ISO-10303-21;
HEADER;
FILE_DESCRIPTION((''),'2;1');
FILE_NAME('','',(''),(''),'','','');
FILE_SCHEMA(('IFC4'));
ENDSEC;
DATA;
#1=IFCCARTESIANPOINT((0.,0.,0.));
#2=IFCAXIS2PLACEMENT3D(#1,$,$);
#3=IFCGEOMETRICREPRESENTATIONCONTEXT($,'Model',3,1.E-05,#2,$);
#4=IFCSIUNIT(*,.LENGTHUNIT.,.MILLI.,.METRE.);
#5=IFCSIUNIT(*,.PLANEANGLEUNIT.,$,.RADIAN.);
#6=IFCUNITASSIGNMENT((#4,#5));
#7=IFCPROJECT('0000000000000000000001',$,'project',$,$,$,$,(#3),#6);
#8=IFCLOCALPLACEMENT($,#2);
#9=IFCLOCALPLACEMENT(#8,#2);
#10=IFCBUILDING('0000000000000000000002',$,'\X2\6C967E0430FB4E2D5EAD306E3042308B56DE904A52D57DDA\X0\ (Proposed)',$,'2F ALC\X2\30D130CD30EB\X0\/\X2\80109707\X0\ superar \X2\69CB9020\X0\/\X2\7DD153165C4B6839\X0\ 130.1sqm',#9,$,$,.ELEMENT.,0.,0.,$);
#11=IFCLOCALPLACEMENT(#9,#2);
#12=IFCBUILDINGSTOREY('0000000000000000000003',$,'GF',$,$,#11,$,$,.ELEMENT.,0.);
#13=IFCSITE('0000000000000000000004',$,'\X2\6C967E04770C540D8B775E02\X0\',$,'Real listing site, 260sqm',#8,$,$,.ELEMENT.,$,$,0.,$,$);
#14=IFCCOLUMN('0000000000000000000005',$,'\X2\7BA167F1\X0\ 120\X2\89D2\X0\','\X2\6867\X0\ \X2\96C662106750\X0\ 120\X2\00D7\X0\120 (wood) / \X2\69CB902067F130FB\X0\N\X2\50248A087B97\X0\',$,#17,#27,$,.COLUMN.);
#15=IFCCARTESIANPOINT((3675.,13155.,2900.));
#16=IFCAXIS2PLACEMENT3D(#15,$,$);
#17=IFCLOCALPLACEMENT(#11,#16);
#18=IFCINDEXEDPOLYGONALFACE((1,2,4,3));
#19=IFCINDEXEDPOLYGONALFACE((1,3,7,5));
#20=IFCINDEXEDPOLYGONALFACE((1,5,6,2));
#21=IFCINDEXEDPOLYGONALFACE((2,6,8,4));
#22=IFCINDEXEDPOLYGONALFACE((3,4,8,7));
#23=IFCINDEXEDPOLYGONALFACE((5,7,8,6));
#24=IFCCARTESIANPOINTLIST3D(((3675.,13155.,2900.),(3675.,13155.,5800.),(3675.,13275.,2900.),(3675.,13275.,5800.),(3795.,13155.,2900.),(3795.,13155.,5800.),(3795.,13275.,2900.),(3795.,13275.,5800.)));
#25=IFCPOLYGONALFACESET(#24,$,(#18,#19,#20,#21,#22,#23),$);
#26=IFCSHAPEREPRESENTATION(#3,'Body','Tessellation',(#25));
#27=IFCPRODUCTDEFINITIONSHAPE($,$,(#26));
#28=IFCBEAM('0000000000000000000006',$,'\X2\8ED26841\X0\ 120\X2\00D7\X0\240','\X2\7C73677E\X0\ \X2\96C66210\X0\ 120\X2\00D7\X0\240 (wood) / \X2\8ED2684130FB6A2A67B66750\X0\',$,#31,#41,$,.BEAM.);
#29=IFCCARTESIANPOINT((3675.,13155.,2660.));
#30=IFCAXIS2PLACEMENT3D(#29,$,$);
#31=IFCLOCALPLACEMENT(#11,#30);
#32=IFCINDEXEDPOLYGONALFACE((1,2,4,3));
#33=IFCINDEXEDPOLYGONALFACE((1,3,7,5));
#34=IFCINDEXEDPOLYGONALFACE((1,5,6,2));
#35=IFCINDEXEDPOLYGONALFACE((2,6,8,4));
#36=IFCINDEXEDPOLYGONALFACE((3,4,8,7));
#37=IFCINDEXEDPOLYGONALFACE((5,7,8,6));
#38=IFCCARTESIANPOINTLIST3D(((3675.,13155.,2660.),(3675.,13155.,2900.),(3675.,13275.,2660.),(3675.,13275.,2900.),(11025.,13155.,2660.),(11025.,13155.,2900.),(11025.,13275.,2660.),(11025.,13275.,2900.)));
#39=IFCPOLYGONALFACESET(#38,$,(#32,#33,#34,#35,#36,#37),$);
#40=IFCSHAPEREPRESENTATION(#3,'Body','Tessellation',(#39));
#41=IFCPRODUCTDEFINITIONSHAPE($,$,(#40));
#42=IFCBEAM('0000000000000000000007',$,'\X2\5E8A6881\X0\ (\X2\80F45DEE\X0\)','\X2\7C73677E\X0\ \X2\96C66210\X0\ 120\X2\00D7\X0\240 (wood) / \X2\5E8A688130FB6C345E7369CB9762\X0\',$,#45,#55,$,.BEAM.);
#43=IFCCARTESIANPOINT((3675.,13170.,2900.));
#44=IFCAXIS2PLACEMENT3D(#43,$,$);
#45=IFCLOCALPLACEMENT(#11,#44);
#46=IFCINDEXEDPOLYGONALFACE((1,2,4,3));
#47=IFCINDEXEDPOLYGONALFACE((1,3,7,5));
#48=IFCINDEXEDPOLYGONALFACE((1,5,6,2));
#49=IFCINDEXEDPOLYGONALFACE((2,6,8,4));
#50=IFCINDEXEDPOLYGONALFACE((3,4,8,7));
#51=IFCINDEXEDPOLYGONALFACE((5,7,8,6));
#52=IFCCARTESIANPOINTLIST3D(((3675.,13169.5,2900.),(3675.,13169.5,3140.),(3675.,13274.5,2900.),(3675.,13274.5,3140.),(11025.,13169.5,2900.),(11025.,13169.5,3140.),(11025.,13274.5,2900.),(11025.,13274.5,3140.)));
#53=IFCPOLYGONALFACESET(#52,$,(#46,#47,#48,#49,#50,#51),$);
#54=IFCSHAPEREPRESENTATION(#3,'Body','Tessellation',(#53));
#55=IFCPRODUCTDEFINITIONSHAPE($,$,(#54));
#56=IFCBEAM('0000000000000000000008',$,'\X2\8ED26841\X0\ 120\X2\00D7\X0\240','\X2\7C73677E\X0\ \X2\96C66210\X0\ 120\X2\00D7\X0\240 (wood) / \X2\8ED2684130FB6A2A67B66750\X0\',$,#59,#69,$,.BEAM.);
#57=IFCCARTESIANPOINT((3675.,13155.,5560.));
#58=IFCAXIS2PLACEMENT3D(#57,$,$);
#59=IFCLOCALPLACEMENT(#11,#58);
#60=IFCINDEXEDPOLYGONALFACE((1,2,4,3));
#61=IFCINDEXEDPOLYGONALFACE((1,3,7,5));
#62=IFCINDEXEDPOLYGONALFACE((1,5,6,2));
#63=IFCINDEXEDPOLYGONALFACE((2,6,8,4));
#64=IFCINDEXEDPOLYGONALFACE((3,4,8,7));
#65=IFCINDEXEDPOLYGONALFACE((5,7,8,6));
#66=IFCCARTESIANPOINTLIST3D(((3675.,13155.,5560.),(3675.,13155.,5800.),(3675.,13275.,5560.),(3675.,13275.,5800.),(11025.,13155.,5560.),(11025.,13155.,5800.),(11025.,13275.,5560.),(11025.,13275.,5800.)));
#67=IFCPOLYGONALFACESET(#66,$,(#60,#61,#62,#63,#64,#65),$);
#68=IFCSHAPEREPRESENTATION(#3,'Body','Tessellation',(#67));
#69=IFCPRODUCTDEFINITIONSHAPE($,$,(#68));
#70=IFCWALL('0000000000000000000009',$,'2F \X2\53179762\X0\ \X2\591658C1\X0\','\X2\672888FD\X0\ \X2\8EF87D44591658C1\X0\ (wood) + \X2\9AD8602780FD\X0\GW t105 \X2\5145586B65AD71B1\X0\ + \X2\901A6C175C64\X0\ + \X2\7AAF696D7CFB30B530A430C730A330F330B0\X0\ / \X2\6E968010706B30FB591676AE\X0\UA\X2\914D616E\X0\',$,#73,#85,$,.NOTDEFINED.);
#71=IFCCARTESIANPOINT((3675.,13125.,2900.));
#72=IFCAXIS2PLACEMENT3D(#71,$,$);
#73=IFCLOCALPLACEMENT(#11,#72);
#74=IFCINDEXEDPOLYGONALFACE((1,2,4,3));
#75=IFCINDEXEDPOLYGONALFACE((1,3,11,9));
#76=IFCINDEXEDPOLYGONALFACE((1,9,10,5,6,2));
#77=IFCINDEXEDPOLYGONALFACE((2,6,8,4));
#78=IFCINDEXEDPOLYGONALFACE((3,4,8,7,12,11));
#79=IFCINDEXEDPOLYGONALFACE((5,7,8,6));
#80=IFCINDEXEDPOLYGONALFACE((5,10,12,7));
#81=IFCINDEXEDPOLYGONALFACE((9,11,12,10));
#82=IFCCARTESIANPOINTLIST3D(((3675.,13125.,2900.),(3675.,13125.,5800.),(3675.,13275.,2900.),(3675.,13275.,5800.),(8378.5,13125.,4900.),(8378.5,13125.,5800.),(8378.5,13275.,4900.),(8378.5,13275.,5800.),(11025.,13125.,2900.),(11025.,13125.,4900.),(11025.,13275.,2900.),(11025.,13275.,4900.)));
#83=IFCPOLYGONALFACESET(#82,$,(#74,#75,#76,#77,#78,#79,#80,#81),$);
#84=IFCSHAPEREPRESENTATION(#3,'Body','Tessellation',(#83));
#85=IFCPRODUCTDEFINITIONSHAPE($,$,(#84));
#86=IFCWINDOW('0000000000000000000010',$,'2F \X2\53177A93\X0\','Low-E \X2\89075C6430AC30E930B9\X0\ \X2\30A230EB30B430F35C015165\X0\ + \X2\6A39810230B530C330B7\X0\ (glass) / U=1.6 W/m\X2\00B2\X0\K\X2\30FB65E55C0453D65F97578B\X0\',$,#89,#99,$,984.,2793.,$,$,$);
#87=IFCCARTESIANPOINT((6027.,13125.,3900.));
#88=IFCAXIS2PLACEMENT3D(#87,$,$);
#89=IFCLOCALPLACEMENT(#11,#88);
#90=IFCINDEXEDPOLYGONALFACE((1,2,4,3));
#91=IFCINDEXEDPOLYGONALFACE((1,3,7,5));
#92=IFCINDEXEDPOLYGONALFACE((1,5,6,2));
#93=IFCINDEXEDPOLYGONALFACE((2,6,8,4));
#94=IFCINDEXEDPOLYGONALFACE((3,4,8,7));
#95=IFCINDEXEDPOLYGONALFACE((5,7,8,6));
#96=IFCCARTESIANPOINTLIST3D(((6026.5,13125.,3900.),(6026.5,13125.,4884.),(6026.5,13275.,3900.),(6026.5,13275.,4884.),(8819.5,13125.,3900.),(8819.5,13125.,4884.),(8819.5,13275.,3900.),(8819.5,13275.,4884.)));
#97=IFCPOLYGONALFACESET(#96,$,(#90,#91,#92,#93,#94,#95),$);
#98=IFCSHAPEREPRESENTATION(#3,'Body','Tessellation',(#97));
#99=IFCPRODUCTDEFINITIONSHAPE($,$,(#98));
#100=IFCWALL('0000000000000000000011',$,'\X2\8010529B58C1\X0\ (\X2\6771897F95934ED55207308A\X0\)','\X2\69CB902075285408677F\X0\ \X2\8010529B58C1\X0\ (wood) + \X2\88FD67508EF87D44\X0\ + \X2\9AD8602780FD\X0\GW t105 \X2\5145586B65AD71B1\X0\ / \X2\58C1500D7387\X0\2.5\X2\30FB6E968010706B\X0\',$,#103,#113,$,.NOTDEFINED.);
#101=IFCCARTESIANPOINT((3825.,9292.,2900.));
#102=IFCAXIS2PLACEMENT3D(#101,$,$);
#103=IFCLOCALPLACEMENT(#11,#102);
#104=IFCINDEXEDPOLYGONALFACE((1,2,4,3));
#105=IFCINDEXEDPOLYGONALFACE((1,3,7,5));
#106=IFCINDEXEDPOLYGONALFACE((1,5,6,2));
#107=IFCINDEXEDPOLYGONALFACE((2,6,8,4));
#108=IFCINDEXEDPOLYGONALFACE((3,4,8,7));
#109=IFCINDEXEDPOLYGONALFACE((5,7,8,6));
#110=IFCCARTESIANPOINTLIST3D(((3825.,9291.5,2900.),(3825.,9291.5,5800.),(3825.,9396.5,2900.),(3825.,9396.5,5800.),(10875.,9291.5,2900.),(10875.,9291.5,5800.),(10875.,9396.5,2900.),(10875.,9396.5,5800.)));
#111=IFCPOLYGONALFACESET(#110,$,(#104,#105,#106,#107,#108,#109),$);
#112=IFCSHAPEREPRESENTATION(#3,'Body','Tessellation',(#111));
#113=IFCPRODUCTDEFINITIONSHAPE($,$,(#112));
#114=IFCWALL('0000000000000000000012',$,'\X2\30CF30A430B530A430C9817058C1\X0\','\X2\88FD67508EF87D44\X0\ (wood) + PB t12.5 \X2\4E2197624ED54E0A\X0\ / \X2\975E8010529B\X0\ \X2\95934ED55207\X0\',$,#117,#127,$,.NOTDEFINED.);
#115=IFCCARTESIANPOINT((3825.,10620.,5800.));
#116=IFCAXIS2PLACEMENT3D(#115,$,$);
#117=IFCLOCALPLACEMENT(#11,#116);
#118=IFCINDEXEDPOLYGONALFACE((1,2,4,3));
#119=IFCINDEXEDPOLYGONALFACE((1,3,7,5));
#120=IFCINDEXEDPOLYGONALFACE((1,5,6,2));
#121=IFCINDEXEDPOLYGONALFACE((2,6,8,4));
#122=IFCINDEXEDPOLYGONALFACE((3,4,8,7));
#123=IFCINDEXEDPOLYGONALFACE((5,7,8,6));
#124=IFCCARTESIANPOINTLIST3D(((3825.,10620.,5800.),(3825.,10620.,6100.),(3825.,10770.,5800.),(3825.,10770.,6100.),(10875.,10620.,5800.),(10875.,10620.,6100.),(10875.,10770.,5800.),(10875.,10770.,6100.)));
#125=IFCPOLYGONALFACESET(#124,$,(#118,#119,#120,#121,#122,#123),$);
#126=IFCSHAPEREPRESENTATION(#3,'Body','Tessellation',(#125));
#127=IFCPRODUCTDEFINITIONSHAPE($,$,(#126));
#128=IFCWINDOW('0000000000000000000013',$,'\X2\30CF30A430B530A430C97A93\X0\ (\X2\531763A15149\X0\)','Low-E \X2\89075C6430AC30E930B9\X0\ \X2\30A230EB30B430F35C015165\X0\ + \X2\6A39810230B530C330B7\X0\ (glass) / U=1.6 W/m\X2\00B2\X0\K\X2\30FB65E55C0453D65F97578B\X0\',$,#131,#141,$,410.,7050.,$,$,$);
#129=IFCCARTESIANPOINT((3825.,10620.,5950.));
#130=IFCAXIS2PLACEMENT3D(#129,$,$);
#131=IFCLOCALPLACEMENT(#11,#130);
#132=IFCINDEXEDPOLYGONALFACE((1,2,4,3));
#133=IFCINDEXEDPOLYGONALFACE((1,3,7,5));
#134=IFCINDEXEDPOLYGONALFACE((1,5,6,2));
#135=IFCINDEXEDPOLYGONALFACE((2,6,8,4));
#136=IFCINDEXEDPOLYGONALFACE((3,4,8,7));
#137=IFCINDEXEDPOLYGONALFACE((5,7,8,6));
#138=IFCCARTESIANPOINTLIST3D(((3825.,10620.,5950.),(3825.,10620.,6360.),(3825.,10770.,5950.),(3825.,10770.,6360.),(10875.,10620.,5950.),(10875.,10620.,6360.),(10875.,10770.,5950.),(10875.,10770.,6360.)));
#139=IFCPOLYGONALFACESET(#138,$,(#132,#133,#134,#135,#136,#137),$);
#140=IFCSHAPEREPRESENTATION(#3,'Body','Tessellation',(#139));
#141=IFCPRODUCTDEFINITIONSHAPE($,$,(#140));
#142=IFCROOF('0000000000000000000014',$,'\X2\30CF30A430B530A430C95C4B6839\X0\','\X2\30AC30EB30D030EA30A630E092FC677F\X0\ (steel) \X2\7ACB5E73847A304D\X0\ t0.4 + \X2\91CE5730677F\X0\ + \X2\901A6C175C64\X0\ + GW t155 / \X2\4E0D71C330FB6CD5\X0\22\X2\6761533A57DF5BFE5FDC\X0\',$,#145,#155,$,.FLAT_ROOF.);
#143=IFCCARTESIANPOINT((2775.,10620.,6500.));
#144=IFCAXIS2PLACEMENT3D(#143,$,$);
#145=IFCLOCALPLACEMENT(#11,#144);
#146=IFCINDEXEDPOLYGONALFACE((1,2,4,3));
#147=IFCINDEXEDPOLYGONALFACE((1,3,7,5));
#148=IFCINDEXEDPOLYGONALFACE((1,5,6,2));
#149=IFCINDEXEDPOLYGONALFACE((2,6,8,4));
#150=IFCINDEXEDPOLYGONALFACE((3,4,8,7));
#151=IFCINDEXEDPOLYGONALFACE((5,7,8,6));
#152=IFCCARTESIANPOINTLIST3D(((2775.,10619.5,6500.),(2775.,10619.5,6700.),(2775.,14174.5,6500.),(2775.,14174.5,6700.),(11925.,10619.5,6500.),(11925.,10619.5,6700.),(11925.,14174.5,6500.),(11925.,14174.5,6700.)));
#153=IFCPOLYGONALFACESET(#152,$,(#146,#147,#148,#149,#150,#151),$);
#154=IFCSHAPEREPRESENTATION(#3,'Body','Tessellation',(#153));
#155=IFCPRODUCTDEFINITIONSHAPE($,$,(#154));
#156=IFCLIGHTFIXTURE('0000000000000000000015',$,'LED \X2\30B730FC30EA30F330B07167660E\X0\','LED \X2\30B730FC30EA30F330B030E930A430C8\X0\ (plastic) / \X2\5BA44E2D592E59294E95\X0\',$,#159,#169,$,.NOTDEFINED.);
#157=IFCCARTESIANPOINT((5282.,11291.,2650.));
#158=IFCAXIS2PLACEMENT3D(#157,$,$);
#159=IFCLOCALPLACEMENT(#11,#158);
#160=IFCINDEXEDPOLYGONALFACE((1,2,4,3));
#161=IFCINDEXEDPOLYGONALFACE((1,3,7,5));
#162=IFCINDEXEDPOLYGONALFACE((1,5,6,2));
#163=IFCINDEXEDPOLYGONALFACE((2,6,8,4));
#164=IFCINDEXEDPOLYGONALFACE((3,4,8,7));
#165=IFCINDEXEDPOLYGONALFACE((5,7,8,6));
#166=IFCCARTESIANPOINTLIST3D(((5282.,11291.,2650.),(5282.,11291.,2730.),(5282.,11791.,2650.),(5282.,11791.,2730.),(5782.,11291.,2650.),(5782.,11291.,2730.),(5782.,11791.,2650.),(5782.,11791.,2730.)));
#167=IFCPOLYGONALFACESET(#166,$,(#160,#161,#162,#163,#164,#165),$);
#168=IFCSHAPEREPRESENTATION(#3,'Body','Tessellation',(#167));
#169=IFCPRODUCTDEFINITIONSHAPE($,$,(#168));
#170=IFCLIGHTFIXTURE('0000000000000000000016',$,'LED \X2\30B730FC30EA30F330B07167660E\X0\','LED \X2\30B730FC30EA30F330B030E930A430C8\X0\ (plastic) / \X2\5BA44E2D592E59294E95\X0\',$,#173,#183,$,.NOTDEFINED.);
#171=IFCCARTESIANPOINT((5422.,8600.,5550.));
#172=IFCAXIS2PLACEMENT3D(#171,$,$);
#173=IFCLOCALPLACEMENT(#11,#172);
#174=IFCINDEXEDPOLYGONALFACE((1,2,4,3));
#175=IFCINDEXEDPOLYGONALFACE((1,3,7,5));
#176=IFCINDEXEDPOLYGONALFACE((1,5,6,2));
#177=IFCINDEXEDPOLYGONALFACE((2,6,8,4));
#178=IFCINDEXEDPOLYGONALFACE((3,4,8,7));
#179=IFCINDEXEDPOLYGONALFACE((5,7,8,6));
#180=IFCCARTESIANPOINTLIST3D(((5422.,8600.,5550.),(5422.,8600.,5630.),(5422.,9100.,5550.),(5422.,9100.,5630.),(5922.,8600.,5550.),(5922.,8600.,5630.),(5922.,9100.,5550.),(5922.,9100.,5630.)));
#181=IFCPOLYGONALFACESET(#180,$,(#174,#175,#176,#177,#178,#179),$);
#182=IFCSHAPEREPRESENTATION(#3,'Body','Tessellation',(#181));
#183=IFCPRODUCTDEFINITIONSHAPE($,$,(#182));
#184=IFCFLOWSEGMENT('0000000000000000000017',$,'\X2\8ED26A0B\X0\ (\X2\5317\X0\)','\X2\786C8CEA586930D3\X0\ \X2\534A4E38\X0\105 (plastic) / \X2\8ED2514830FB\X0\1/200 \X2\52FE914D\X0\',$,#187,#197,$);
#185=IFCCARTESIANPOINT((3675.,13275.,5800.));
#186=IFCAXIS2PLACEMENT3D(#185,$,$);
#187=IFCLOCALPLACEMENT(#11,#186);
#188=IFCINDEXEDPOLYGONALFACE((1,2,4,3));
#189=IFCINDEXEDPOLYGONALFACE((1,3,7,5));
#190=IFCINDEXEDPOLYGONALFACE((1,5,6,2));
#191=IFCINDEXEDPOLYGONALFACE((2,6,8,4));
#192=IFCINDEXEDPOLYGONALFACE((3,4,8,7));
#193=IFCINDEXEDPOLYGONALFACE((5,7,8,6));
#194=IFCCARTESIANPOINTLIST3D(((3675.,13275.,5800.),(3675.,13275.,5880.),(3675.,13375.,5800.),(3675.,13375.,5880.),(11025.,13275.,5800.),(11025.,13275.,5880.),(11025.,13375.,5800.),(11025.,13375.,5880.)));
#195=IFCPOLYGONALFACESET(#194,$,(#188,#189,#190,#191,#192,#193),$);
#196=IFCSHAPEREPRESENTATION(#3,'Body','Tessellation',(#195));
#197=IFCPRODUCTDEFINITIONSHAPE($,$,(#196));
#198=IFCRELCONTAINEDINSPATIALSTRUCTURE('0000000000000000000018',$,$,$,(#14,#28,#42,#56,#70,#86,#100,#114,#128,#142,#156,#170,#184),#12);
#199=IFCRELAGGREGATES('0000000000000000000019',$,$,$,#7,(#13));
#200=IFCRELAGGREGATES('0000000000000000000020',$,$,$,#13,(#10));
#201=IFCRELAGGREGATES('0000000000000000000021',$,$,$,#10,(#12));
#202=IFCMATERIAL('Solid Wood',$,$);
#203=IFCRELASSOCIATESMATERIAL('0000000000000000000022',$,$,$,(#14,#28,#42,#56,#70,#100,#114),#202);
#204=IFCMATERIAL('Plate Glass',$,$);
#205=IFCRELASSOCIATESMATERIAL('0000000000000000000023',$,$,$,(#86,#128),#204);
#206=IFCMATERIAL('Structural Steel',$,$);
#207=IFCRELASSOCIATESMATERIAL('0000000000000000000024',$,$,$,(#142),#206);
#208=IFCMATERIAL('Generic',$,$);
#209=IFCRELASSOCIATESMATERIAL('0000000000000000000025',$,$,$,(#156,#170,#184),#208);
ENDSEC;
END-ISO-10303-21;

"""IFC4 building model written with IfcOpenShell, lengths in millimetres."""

from ifc_helpers import new_model, si_unit, frame, frame_2d, origin, place, context, project, spatial, rectangle, extrude, material, element, fill, save


model = new_model("IFC4")

# Units and contexts
model_context = context("Model", 3, precision=1e-05, world=origin())
ifc_project = project(units=[si_unit("LENGTHUNIT", "METRE", prefix="MILLI"), si_unit("PLANEANGLEUNIT", "RADIAN")], contexts=[model_context])

# Site, building, storey
site_placement = place(None, origin())
site = spatial("IfcSite", under=ifc_project, at=site_placement, Name="沖縄県名護市", ObjectType="Real listing site, 260sqm", CompositionType="ELEMENT", RefElevation=0.0)
building_placement = place(site_placement, origin())
building = spatial("IfcBuilding", under=site, at=building_placement, Name="沖縄・中庭のある回遊動線 (Proposed)", ObjectType="2F ALCパネル/耐震 superar 構造/緑化屋根 130.1sqm", CompositionType="ELEMENT", ElevationOfRefHeight=0.0, ElevationOfTerrain=0.0)
storey_placement = place(building_placement, origin())
storey = spatial("IfcBuildingStorey", under=building, at=storey_placement, Name="GF", CompositionType="ELEMENT", Elevation=0.0)

# Column
ifc_material_1 = material(Name="Solid Wood")
column_1_placement = place(storey_placement, frame((3675.0, 13155.0, 2900.0)))
element("IfcColumn", 1, at=column_1_placement, inside=storey, material=ifc_material_1, Name="管柱 120角", Description="桧 集成材 120×120 (wood) / 構造柱・N値計算", PredefinedType="COLUMN", context=model_context, shape_type="SweptSolid", body=[
    extrude(rectangle(XDim=120.0, YDim=120.0, at=frame_2d((60.0, 60.0))), frame((3675.0, 13155.0, 2900.0)), (0.0, 0.0, 1.0), 2900.0),
])

# Beams
beam_1_placement = place(storey_placement, frame((3675.0, 13155.0, 2660.0)))
element("IfcBeam", 2, at=beam_1_placement, inside=storey, material=ifc_material_1, Name="軒桁 120×240", Description="米松 集成 120×240 (wood) / 軒桁・横架材", PredefinedType="BEAM", context=model_context, shape_type="SweptSolid", body=[
    extrude(rectangle(XDim=7350.0, YDim=120.0, at=frame_2d((3675.0, 60.0))), frame((3675.0, 13155.0, 2660.0)), (0.0, 0.0, 1.0), 240.0),
])
beam_2_placement = place(storey_placement, frame((3675.0, 13170.0, 2900.0)))
element("IfcBeam", 3, at=beam_2_placement, inside=storey, material=ifc_material_1, Name="床梁 (胴差)", Description="米松 集成 120×240 (wood) / 床梁・水平構面", PredefinedType="BEAM", context=model_context, shape_type="SweptSolid", body=[
    extrude(rectangle(XDim=7350.0, YDim=105.0, at=frame_2d((3675.0, 52.0))), frame((3675.0, 13170.0, 2900.0)), (0.0, 0.0, 1.0), 240.0),
])
beam_3_placement = place(storey_placement, frame((3675.0, 13155.0, 5560.0)))
element("IfcBeam", 4, at=beam_3_placement, inside=storey, material=ifc_material_1, Name="軒桁 120×240", Description="米松 集成 120×240 (wood) / 軒桁・横架材", PredefinedType="BEAM", context=model_context, shape_type="SweptSolid", body=[
    extrude(rectangle(XDim=7350.0, YDim=120.0, at=frame_2d((3675.0, 60.0))), frame((3675.0, 13155.0, 5560.0)), (0.0, 0.0, 1.0), 240.0),
])

# Wall, opening, window
wall_1_placement = place(storey_placement, frame((3675.0, 13125.0, 2900.0)))
wall_1 = element("IfcWall", 5, at=wall_1_placement, inside=storey, material=ifc_material_1, Name="2F 北面 外壁", Description="木製 軸組外壁 (wood) + 高性能GW t105 充填断熱 + 通気層 + 窯業系サイディング / 準耐火・外皮UA配慮", PredefinedType="NOTDEFINED", context=model_context, shape_type="SweptSolid", body=[
    extrude(rectangle(XDim=7350.0, YDim=150.0, at=frame_2d((3675.0, 75.0))), frame((3675.0, 13125.0, 2900.0)), (0.0, 0.0, 1.0), 2900.0),
])
opening_1_placement = place(storey_placement, frame((6027.0, 13125.0, 3900.0)))
opening_1 = element("IfcOpeningElement", 6, at=opening_1_placement, cuts=wall_1, PredefinedType="NOTDEFINED", context=model_context, shape_type="SweptSolid", body=[
    extrude(rectangle(XDim=2793.0, YDim=150.0, at=frame_2d((1396.0, 75.0))), frame((6027.0, 13125.0, 3900.0)), (0.0, 0.0, 1.0), 984.0),
])
ifc_material_2 = material(Name="Plate Glass")
window_1_placement = place(storey_placement, frame((6027.0, 13125.0, 3900.0)))
window_1 = element("IfcWindow", 7, at=window_1_placement, inside=storey, material=ifc_material_2, Name="2F 北窓", Description="Low-E 複層ガラス アルゴン封入 + 樹脂サッシ (glass) / U=1.6 W/m²K・日射取得型", OverallHeight=984.0, OverallWidth=2793.0, context=model_context, shape_type="SweptSolid", body=[
    extrude(rectangle(XDim=2793.0, YDim=150.0, at=frame_2d((1396.0, 75.0))), frame((6027.0, 13125.0, 3900.0)), (0.0, 0.0, 1.0), 984.0),
])
fill(opening_1, window_1)

# Wall
wall_2_placement = place(storey_placement, frame((3825.0, 9292.0, 2900.0)))
element("IfcWall", 8, at=wall_2_placement, inside=storey, material=ifc_material_1, Name="耐力壁 (東西間仕切り)", Description="構造用合板 耐力壁 (wood) + 製材軸組 + 高性能GW t105 充填断熱 / 壁倍率2.5・準耐火", PredefinedType="NOTDEFINED", context=model_context, shape_type="SweptSolid", body=[
    extrude(rectangle(XDim=7050.0, YDim=105.0, at=frame_2d((3525.0, 52.0))), frame((3825.0, 9292.0, 2900.0)), (0.0, 0.0, 1.0), 2900.0),
])

# Wall, opening, window
wall_3_placement = place(storey_placement, frame((3825.0, 10620.0, 5800.0)))
wall_3 = element("IfcWall", 9, at=wall_3_placement, inside=storey, material=ifc_material_1, Name="ハイサイド腰壁", Description="製材軸組 (wood) + PB t12.5 両面仕上 / 非耐力 間仕切", PredefinedType="NOTDEFINED", context=model_context, shape_type="SweptSolid", body=[
    extrude(rectangle(XDim=7050.0, YDim=150.0, at=frame_2d((3525.0, 75.0))), frame((3825.0, 10620.0, 5800.0)), (0.0, 0.0, 1.0), 700.0),
])
opening_2_placement = place(storey_placement, frame((3825.0, 10620.0, 5950.0)))
opening_2 = element("IfcOpeningElement", 10, at=opening_2_placement, cuts=wall_3, PredefinedType="NOTDEFINED", context=model_context, shape_type="SweptSolid", body=[
    extrude(rectangle(XDim=7050.0, YDim=150.0, at=frame_2d((3525.0, 75.0))), frame((3825.0, 10620.0, 5950.0)), (0.0, 0.0, 1.0), 410.0),
])
window_2_placement = place(storey_placement, frame((3825.0, 10620.0, 5950.0)))
window_2 = element("IfcWindow", 11, at=window_2_placement, inside=storey, material=ifc_material_2, Name="ハイサイド窓 (北採光)", Description="Low-E 複層ガラス アルゴン封入 + 樹脂サッシ (glass) / U=1.6 W/m²K・日射取得型", OverallHeight=410.0, OverallWidth=7050.0, context=model_context, shape_type="SweptSolid", body=[
    extrude(rectangle(XDim=7050.0, YDim=150.0, at=frame_2d((3525.0, 75.0))), frame((3825.0, 10620.0, 5950.0)), (0.0, 0.0, 1.0), 410.0),
])
fill(opening_2, window_2)

# Roof
ifc_material_3 = material(Name="Structural Steel")
roof_placement = place(storey_placement, frame((2775.0, 10620.0, 6500.0)))
element("IfcRoof", 12, at=roof_placement, inside=storey, material=ifc_material_3, Name="ハイサイド屋根", Description="ガルバリウム鋼板 (steel) 立平葺き t0.4 + 野地板 + 通気層 + GW t155 / 不燃・法22条区域対応", PredefinedType="FLAT_ROOF", context=model_context, shape_type="SweptSolid", body=[
    extrude(rectangle(XDim=9150.0, YDim=3555.0, at=frame_2d((4575.0, 1777.0))), frame((2775.0, 10620.0, 6500.0)), (0.0, 0.0, 1.0), 200.0),
])

# Light fixtures
ifc_material_4 = material(Name="Generic")
light_fixture_1_placement = place(storey_placement, frame((5282.0, 11291.0, 2650.0)))
element("IfcLightFixture", 13, at=light_fixture_1_placement, inside=storey, material=ifc_material_4, Name="LED シーリング照明", Description="LED シーリングライト (plastic) / 室中央天井", PredefinedType="NOTDEFINED", context=model_context, shape_type="SweptSolid", body=[
    extrude(rectangle(XDim=500.0, YDim=500.0, at=frame_2d((250.0, 250.0))), frame((5282.0, 11291.0, 2650.0)), (0.0, 0.0, 1.0), 80.0),
])
light_fixture_2_placement = place(storey_placement, frame((5422.0, 8600.0, 5550.0)))
element("IfcLightFixture", 14, at=light_fixture_2_placement, inside=storey, material=ifc_material_4, Name="LED シーリング照明", Description="LED シーリングライト (plastic) / 室中央天井", PredefinedType="NOTDEFINED", context=model_context, shape_type="SweptSolid", body=[
    extrude(rectangle(XDim=500.0, YDim=500.0, at=frame_2d((250.0, 250.0))), frame((5422.0, 8600.0, 5550.0)), (0.0, 0.0, 1.0), 80.0),
])

# Flow segment
flow_segment_placement = place(storey_placement, frame((3675.0, 13275.0, 5800.0)))
element("IfcFlowSegment", 15, at=flow_segment_placement, inside=storey, material=ifc_material_4, Name="軒樋 (北)", Description="硬質塩ビ 半丸105 (plastic) / 軒先・1/200 勾配", context=model_context, shape_type="SweptSolid", body=[
    extrude(rectangle(XDim=7350.0, YDim=100.0, at=frame_2d((3675.0, 50.0))), frame((3675.0, 13275.0, 5800.0)), (0.0, 0.0, 1.0), 80.0),
])

save(model, "model.ifc")
